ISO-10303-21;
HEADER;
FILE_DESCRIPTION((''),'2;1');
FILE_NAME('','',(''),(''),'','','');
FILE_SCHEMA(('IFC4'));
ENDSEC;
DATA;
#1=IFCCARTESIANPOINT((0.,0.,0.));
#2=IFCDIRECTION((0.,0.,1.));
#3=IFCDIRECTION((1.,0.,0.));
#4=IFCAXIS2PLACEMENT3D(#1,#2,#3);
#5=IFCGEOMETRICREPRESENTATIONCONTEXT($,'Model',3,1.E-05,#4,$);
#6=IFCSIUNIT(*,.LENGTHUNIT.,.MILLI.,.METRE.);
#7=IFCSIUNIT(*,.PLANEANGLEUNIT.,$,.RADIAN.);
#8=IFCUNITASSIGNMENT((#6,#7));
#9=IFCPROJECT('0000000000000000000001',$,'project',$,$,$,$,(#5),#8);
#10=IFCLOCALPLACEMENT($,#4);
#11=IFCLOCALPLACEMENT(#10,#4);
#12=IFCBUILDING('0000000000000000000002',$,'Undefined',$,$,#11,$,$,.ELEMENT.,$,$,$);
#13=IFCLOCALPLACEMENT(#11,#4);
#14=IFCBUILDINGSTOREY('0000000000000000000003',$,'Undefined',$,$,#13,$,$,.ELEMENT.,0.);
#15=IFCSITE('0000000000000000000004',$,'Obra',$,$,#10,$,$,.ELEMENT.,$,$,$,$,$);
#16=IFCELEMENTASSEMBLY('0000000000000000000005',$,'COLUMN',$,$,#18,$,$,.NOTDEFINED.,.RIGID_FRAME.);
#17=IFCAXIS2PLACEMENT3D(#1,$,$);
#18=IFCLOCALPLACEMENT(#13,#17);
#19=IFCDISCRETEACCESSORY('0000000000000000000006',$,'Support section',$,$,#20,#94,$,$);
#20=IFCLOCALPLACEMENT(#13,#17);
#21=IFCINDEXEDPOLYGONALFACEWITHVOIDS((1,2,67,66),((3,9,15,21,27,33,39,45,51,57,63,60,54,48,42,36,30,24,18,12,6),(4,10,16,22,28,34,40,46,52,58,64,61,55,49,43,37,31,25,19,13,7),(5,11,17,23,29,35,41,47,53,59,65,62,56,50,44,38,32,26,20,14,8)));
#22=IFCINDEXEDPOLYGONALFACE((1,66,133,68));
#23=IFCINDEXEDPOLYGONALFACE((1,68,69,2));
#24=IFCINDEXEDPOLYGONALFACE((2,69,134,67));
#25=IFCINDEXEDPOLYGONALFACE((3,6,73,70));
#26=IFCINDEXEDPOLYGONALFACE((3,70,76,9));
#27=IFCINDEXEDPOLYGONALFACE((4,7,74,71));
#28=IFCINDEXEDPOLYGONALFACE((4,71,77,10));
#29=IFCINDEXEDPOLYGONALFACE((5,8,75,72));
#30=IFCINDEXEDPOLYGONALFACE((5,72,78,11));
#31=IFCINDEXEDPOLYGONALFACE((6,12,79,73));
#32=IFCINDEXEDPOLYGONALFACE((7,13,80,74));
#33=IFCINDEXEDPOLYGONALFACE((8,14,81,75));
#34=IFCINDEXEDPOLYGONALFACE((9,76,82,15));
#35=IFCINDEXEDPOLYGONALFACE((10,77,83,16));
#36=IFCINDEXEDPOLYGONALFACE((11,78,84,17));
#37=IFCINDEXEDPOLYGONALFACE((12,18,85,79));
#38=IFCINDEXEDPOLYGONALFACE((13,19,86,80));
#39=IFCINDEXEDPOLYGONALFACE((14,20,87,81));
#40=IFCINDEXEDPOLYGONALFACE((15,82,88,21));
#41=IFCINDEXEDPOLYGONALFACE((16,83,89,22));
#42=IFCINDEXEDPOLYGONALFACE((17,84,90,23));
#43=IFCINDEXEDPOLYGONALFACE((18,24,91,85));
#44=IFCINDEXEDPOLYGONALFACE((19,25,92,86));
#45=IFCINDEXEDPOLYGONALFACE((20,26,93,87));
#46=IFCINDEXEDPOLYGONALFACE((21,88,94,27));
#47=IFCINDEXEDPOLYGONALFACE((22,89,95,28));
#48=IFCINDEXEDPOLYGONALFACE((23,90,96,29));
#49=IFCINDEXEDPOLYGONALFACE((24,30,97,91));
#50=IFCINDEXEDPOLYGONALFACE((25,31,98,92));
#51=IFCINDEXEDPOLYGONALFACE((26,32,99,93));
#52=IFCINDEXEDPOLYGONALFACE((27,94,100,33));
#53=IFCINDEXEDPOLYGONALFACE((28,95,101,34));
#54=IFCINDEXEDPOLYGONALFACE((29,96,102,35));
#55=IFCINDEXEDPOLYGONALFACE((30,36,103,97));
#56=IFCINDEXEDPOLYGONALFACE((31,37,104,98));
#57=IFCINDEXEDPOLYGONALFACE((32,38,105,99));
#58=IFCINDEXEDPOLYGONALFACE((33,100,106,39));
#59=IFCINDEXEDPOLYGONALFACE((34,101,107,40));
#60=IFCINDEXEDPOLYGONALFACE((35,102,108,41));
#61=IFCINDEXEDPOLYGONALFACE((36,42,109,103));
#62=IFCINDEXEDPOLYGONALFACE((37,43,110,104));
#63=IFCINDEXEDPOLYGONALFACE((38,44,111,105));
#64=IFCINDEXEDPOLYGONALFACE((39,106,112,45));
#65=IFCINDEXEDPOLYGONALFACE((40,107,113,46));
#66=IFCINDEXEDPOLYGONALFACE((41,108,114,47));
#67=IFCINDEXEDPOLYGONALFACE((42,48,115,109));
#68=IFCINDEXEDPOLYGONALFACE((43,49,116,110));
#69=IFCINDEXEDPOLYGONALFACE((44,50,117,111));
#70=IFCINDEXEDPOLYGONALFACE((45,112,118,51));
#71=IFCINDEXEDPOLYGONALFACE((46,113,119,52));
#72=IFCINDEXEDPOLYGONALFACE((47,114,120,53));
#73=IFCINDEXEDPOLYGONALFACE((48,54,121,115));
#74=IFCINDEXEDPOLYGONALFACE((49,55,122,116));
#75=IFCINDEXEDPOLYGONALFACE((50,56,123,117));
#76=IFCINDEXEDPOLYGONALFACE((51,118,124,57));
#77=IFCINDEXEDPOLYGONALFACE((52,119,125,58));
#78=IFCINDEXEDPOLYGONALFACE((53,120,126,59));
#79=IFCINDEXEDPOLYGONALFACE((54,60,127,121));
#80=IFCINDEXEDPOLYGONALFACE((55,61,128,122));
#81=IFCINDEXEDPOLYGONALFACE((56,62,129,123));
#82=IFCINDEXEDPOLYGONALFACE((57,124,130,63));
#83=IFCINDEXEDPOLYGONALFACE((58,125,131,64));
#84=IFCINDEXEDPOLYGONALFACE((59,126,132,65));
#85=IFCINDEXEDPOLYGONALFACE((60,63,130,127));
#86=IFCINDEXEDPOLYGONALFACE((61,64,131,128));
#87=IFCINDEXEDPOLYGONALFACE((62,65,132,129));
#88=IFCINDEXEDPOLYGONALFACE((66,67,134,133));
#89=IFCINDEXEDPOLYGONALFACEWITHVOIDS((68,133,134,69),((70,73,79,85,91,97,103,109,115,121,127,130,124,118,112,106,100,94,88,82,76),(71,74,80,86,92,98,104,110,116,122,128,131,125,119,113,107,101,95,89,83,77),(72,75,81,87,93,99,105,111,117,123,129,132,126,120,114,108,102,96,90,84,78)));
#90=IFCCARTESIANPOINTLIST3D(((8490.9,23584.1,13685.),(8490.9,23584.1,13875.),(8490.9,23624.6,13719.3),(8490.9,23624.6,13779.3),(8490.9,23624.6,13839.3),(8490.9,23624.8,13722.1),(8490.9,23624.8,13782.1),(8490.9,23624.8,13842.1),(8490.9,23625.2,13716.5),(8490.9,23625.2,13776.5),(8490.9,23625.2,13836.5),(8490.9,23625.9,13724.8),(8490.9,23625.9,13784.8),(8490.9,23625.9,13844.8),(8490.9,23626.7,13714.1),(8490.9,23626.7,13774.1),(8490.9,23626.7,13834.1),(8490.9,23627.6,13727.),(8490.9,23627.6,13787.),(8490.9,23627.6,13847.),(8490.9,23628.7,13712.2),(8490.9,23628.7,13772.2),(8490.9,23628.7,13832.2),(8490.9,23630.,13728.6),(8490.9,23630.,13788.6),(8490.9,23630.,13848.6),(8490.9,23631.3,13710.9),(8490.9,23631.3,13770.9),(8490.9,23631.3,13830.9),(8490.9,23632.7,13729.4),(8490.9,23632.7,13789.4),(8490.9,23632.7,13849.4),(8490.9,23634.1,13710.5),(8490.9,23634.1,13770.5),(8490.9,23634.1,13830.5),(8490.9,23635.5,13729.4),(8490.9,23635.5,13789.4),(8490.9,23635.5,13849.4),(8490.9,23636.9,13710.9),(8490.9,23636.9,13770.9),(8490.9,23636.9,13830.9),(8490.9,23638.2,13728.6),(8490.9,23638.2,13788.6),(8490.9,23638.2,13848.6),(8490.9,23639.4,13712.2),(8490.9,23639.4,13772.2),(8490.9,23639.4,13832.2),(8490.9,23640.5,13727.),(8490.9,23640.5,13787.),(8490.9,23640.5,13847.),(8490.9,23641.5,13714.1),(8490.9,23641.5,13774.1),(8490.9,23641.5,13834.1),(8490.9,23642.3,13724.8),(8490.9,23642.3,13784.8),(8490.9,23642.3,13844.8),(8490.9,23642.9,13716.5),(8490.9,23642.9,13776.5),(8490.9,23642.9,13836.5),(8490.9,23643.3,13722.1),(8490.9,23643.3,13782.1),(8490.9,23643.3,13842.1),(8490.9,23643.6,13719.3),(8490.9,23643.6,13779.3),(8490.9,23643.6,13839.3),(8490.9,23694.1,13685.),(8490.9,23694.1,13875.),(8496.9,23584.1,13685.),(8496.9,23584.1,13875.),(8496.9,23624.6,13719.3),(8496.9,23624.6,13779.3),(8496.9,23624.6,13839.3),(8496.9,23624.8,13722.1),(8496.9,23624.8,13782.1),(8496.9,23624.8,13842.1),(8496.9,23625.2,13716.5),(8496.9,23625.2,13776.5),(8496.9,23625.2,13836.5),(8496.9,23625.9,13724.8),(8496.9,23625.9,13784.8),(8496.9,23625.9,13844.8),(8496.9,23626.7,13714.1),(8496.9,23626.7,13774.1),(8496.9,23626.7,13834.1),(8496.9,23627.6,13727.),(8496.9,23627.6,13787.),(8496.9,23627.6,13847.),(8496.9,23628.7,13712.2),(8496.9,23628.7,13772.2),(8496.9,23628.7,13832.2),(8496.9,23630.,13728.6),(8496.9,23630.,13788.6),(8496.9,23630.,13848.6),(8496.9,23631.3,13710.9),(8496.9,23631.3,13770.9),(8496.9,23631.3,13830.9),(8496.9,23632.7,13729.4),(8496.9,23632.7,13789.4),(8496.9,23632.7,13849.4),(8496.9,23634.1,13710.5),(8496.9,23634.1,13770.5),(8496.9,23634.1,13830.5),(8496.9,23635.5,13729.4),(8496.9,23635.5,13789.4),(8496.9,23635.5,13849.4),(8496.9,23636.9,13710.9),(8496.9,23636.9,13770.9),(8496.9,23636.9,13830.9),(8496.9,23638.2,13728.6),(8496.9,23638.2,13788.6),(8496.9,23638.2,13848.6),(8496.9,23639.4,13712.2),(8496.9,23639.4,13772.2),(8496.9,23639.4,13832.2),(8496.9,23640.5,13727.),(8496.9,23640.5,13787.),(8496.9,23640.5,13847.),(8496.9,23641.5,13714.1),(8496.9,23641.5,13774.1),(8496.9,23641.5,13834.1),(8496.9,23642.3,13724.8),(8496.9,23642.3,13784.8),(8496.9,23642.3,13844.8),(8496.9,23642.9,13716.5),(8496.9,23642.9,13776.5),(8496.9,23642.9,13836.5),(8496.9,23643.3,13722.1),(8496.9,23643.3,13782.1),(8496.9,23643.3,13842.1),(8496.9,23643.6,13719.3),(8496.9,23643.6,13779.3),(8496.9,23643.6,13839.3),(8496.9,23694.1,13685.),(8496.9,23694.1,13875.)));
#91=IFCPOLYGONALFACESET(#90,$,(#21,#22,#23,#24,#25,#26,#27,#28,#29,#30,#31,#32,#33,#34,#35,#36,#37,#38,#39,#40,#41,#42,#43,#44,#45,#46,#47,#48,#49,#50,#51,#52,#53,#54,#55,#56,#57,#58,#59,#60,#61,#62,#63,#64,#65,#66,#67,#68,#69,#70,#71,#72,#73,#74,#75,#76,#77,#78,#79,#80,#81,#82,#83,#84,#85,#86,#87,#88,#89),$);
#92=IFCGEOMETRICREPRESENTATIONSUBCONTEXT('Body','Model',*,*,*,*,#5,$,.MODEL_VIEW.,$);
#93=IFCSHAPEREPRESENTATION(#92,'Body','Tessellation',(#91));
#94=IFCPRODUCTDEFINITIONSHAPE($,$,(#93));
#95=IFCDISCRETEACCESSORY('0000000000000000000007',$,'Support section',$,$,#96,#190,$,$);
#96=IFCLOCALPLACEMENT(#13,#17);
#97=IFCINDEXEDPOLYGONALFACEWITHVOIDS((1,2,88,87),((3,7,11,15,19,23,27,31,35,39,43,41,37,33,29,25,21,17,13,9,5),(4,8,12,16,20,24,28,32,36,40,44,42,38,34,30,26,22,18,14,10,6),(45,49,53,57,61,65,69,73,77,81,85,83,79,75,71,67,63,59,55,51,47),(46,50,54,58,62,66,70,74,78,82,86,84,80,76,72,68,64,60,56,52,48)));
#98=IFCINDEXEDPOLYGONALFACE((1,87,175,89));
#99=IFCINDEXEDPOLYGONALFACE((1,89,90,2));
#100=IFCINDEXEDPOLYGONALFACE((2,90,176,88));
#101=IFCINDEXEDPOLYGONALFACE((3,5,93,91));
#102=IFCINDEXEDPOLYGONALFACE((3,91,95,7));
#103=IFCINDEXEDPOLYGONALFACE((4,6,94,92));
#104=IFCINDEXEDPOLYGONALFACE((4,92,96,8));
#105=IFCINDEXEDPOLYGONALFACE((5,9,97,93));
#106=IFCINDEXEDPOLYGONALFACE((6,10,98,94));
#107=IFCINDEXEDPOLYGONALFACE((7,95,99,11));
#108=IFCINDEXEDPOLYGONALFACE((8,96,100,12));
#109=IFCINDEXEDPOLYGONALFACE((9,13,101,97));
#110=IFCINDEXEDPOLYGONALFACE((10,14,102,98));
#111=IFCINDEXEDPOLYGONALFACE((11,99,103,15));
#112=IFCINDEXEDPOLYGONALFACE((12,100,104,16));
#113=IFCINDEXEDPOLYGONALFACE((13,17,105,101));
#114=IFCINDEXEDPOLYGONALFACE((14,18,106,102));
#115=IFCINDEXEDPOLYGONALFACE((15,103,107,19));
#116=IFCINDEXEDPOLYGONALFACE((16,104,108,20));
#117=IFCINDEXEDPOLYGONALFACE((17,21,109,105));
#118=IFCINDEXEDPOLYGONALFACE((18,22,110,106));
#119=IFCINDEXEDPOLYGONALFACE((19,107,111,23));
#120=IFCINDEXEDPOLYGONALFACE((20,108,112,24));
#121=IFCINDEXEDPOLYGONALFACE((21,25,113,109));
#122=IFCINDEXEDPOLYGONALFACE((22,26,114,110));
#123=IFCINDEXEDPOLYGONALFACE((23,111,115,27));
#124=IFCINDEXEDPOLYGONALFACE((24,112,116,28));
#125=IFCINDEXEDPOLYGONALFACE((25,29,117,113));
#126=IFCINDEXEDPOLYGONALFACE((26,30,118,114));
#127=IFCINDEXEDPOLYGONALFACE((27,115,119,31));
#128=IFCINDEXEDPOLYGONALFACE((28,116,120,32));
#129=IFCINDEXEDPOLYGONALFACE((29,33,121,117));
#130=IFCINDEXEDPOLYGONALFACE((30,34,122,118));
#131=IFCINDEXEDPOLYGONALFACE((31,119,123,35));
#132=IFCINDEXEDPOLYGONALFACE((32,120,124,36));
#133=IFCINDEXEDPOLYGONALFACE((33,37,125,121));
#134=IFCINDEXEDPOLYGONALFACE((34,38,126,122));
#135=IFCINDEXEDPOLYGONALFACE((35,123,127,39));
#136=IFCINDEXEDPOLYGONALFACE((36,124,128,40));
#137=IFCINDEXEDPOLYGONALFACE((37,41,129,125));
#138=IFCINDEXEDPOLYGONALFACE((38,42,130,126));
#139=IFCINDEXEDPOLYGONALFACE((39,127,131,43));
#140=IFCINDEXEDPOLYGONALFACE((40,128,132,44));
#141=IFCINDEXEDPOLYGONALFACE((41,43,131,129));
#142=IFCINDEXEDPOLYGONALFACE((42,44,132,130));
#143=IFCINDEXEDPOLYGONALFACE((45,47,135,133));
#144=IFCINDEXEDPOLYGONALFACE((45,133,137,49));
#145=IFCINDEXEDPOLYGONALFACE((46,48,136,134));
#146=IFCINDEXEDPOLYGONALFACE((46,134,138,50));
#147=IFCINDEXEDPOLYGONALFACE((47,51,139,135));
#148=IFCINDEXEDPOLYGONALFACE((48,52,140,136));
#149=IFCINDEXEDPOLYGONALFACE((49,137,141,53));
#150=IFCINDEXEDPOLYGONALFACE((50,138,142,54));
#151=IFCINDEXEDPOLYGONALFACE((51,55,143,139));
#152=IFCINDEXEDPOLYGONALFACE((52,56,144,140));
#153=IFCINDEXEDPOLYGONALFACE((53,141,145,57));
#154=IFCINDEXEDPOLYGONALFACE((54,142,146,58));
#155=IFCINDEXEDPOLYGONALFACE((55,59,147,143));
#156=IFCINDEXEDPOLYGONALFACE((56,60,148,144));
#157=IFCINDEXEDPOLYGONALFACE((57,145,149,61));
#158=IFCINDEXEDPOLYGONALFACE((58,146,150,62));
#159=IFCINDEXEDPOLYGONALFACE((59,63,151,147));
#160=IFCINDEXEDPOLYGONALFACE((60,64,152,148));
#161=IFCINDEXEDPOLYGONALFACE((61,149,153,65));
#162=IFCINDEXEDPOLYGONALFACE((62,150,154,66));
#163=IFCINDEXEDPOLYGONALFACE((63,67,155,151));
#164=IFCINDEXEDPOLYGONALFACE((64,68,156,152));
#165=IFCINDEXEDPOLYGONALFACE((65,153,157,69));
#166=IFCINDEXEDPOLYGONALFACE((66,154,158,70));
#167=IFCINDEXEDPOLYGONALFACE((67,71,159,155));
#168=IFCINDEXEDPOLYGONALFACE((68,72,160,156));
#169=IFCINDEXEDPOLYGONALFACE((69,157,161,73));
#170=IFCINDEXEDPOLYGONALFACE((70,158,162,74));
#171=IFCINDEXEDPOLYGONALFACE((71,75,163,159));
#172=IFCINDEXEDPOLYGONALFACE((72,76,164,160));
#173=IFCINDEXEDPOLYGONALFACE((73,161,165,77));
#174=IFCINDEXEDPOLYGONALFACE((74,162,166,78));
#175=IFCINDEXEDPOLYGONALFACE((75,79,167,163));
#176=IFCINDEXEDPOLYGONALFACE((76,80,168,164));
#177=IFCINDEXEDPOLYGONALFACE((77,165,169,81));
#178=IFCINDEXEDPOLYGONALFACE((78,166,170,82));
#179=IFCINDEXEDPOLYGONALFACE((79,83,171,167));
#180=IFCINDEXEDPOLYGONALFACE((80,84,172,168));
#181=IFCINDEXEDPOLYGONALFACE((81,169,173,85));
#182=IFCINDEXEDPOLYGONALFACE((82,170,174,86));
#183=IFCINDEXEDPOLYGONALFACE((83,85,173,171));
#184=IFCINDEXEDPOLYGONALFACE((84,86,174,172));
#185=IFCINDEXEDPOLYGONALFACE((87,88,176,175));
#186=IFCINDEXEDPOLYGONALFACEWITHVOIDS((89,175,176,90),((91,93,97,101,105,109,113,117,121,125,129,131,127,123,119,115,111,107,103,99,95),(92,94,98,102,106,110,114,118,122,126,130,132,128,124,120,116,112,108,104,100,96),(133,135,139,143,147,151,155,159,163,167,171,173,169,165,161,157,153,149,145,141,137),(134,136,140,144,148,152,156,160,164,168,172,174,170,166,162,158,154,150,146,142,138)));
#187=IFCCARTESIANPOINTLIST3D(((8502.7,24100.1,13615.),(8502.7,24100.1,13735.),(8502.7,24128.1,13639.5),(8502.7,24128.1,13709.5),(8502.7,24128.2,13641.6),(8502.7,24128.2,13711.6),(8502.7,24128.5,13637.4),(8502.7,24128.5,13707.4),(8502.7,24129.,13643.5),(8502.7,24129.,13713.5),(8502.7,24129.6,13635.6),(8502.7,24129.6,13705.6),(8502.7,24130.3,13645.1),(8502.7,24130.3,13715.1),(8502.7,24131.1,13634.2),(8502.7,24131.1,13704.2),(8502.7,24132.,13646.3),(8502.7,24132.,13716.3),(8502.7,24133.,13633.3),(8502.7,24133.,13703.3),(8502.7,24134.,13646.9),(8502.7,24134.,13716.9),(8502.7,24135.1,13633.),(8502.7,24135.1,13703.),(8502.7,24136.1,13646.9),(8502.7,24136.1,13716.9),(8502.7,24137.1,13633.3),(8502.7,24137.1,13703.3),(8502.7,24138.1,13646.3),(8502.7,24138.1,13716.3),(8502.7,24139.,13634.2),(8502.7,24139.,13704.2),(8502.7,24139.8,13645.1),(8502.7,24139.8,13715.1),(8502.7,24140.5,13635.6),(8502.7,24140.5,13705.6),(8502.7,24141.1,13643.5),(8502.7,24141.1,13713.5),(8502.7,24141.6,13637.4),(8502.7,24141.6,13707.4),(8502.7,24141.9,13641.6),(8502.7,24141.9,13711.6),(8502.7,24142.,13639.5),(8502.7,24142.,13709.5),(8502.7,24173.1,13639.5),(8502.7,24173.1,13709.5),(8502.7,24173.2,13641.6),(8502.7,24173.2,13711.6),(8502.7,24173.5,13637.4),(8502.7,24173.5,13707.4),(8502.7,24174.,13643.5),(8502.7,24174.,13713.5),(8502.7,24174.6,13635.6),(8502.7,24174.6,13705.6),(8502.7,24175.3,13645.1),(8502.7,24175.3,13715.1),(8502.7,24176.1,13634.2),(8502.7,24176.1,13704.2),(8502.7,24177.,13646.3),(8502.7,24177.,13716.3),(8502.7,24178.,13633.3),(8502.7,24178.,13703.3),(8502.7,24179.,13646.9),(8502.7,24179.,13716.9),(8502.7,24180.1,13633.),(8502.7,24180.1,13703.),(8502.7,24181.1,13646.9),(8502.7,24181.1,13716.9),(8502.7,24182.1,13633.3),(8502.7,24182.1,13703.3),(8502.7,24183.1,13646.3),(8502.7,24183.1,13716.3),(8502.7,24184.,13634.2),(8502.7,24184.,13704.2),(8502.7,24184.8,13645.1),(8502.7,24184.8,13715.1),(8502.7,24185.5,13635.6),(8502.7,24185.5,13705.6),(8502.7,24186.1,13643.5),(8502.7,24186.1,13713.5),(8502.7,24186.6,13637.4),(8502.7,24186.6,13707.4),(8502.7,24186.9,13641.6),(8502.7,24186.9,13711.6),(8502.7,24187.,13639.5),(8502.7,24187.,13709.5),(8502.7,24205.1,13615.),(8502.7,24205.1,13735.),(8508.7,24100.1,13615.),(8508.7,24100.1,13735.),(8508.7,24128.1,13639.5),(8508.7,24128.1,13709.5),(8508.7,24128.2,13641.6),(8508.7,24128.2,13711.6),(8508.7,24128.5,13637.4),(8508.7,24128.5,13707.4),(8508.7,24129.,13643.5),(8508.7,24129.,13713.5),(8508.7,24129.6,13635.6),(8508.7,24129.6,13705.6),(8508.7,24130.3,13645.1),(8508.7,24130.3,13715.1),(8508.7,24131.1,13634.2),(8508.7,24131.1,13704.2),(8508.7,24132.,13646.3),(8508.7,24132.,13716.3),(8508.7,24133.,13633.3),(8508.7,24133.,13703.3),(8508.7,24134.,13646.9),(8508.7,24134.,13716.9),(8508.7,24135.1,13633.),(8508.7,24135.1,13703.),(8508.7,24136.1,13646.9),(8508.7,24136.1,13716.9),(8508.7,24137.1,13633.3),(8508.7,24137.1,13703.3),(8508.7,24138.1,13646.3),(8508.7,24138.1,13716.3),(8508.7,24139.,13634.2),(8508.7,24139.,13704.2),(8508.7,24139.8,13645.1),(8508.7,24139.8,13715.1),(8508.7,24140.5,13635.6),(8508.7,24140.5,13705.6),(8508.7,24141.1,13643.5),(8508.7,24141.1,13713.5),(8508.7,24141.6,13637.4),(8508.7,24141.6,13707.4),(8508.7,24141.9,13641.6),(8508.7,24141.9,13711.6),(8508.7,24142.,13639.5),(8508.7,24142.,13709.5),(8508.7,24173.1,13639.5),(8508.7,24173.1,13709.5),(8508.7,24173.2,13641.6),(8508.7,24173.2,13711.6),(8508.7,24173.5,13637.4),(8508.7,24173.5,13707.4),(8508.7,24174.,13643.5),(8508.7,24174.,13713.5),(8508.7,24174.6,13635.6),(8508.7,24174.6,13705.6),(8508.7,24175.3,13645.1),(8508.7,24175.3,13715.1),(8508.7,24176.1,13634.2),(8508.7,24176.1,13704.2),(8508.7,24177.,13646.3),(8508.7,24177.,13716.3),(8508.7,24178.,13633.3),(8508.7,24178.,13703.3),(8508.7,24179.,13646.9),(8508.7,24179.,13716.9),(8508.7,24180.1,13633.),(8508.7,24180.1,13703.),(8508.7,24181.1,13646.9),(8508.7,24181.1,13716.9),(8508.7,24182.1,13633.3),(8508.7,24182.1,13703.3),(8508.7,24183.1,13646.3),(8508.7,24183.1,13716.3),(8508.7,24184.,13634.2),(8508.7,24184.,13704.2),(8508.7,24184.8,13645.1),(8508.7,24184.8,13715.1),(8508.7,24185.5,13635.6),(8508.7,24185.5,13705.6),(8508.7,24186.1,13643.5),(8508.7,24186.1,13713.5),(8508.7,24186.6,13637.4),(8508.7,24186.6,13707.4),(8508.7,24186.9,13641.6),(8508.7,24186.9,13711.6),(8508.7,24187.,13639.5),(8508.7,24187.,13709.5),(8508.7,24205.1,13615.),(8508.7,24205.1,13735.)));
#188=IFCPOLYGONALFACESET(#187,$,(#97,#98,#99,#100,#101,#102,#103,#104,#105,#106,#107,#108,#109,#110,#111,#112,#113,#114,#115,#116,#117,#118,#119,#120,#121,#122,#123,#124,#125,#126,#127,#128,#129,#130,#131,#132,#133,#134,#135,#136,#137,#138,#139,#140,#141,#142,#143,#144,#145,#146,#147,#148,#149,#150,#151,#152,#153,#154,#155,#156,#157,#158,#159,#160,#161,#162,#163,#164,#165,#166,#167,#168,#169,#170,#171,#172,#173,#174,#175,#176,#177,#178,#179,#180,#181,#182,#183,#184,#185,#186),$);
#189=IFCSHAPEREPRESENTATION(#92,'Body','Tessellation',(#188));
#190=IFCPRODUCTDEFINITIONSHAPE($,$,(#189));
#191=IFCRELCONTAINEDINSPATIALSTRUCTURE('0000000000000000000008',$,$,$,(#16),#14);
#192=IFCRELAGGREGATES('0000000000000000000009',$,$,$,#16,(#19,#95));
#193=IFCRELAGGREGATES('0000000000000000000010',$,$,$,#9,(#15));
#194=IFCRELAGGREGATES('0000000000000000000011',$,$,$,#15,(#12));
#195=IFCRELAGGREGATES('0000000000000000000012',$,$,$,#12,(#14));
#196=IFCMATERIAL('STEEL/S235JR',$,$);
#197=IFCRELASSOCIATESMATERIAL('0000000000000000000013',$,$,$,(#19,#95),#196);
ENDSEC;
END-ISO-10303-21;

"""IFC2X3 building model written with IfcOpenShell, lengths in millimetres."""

from ifc_helpers import new_model, si_unit, frame, origin_with_axes, origin_2d_with_axis, place, context, subcontext, project, spatial, rectangle, circle, extrude, source, transform, mapped, material, element, aggregate, save


model = new_model("IFC2X3")

# Units and contexts
model_context = context("Model", 3, precision=1e-05, world=origin_with_axes())
body_context = subcontext(model_context, "Body", "Model", "MODEL_VIEW")
ifc_project = project(units=[si_unit("LENGTHUNIT", "METRE", prefix="MILLI"), si_unit("PLANEANGLEUNIT", "RADIAN")], contexts=[model_context])

# Site, building, storey
site_placement = place(None, origin_with_axes())
site = spatial("IfcSite", under=ifc_project, at=site_placement, Name="Obra", CompositionType="ELEMENT")
building_placement = place(site_placement, origin_with_axes())
building = spatial("IfcBuilding", under=site, at=building_placement, Name="Undefined", CompositionType="ELEMENT")
storey_placement = place(building_placement, origin_with_axes())
storey = spatial("IfcBuildingStorey", under=building, at=storey_placement, Name="Undefined", CompositionType="ELEMENT", Elevation=0.0)

# Element assembly
assembly_1_placement = place(storey_placement, origin_with_axes())
assembly_1 = element("IfcElementAssembly", 1, at=assembly_1_placement, inside=storey, Name="COLUMN", AssemblyPlace="NOTDEFINED", PredefinedType="RIGID_FRAME")
ifc_material_1 = material(Name="STEEL/S235JR")

# Discrete accessories, openings
shared_shape_1 = source(origin_with_axes(), body_context, "Body", "SweptSolid", [
    extrude(circle(Radius=7.0, at=origin_2d_with_axis()), frame((0.0, -8.6, 0.0), z_axis=(0.0, 1.0, 0.0), x_axis=(1.0, 0.0, 0.0)), (0.0, 0.0, 1.0), 6.2),
])
discrete_accessory_1_placement = place(assembly_1_placement, frame((8493.9, 23639.1, 13685.0), z_axis=(0.0, 0.0, 1.0), x_axis=(0.0, 1.0, 0.0)))
discrete_accessory_1 = element("IfcDiscreteAccessory", 2, at=discrete_accessory_1_placement, material=ifc_material_1, Name="Support section", context=body_context, shape_type="SweptSolid", body=[
    extrude(rectangle(XDim=6.0, YDim=110.0, at=origin_2d_with_axis()), frame((0.0, 0.0, 190.0), z_axis=(0.0, 0.0, -1.0), x_axis=(0.0, 1.0, 0.0)), (0.0, 0.0, 1.0), 190.0),
])
shared_shape_2 = source(origin_with_axes(), body_context, "Body", "SweptSolid", [
    extrude(circle(Radius=9.5, at=origin_2d_with_axis()), frame((0.0, -9.2, 0.0), z_axis=(0.0, 1.0, 0.0), x_axis=(1.0, 0.0, 0.0)), (0.0, 0.0, 1.0), 6.2),
])
opening_1_placement = place(assembly_1_placement, frame((8500.0, 23684.1, 13900.0), z_axis=(0.0, -1.0, 0.0), x_axis=(0.0, 0.0, -1.0)))
element("IfcOpeningElement", 3, at=opening_1_placement, cuts=discrete_accessory_1, ObjectType="Opening", context=body_context, shape_type="MappedRepresentation", body=[
    mapped(shared_shape_2, transform((60.0, 0.0, 50.0))),
    mapped(shared_shape_2, transform((120.0, 0.0, 50.0))),
    mapped(shared_shape_2, transform((180.0, 0.0, 50.0))),
])
discrete_accessory_2_placement = place(assembly_1_placement, frame((8505.7, 24152.6, 13615.0), z_axis=(0.0, 0.0, 1.0), x_axis=(0.0, -1.0, 0.0)))
discrete_accessory_2 = element("IfcDiscreteAccessory", 4, at=discrete_accessory_2_placement, material=ifc_material_1, Name="Support section", context=body_context, shape_type="SweptSolid", body=[
    extrude(rectangle(XDim=6.0, YDim=105.0, at=origin_2d_with_axis()), frame((0.0, 0.0, 120.0), z_axis=(0.0, 0.0, -1.0), x_axis=(0.0, 1.0, 0.0)), (0.0, 0.0, 1.0), 120.0),
])
opening_2_placement = place(assembly_1_placement, frame((8500.2, 24110.1, 13755.0), z_axis=(0.0, 1.0, 0.0), x_axis=(0.0, 0.0, -1.0)))
element("IfcOpeningElement", 5, at=opening_2_placement, cuts=discrete_accessory_2, ObjectType="Opening", context=body_context, shape_type="MappedRepresentation", body=[
    mapped(shared_shape_1, transform((45.0, 0.0, 25.0))),
    mapped(shared_shape_1, transform((45.0, 0.0, 70.0))),
    mapped(shared_shape_1, transform((115.0, 0.0, 25.0))),
    mapped(shared_shape_1, transform((115.0, 0.0, 70.0))),
])
aggregate(assembly_1, [discrete_accessory_1, discrete_accessory_2])

save(model, "model.ifc")
